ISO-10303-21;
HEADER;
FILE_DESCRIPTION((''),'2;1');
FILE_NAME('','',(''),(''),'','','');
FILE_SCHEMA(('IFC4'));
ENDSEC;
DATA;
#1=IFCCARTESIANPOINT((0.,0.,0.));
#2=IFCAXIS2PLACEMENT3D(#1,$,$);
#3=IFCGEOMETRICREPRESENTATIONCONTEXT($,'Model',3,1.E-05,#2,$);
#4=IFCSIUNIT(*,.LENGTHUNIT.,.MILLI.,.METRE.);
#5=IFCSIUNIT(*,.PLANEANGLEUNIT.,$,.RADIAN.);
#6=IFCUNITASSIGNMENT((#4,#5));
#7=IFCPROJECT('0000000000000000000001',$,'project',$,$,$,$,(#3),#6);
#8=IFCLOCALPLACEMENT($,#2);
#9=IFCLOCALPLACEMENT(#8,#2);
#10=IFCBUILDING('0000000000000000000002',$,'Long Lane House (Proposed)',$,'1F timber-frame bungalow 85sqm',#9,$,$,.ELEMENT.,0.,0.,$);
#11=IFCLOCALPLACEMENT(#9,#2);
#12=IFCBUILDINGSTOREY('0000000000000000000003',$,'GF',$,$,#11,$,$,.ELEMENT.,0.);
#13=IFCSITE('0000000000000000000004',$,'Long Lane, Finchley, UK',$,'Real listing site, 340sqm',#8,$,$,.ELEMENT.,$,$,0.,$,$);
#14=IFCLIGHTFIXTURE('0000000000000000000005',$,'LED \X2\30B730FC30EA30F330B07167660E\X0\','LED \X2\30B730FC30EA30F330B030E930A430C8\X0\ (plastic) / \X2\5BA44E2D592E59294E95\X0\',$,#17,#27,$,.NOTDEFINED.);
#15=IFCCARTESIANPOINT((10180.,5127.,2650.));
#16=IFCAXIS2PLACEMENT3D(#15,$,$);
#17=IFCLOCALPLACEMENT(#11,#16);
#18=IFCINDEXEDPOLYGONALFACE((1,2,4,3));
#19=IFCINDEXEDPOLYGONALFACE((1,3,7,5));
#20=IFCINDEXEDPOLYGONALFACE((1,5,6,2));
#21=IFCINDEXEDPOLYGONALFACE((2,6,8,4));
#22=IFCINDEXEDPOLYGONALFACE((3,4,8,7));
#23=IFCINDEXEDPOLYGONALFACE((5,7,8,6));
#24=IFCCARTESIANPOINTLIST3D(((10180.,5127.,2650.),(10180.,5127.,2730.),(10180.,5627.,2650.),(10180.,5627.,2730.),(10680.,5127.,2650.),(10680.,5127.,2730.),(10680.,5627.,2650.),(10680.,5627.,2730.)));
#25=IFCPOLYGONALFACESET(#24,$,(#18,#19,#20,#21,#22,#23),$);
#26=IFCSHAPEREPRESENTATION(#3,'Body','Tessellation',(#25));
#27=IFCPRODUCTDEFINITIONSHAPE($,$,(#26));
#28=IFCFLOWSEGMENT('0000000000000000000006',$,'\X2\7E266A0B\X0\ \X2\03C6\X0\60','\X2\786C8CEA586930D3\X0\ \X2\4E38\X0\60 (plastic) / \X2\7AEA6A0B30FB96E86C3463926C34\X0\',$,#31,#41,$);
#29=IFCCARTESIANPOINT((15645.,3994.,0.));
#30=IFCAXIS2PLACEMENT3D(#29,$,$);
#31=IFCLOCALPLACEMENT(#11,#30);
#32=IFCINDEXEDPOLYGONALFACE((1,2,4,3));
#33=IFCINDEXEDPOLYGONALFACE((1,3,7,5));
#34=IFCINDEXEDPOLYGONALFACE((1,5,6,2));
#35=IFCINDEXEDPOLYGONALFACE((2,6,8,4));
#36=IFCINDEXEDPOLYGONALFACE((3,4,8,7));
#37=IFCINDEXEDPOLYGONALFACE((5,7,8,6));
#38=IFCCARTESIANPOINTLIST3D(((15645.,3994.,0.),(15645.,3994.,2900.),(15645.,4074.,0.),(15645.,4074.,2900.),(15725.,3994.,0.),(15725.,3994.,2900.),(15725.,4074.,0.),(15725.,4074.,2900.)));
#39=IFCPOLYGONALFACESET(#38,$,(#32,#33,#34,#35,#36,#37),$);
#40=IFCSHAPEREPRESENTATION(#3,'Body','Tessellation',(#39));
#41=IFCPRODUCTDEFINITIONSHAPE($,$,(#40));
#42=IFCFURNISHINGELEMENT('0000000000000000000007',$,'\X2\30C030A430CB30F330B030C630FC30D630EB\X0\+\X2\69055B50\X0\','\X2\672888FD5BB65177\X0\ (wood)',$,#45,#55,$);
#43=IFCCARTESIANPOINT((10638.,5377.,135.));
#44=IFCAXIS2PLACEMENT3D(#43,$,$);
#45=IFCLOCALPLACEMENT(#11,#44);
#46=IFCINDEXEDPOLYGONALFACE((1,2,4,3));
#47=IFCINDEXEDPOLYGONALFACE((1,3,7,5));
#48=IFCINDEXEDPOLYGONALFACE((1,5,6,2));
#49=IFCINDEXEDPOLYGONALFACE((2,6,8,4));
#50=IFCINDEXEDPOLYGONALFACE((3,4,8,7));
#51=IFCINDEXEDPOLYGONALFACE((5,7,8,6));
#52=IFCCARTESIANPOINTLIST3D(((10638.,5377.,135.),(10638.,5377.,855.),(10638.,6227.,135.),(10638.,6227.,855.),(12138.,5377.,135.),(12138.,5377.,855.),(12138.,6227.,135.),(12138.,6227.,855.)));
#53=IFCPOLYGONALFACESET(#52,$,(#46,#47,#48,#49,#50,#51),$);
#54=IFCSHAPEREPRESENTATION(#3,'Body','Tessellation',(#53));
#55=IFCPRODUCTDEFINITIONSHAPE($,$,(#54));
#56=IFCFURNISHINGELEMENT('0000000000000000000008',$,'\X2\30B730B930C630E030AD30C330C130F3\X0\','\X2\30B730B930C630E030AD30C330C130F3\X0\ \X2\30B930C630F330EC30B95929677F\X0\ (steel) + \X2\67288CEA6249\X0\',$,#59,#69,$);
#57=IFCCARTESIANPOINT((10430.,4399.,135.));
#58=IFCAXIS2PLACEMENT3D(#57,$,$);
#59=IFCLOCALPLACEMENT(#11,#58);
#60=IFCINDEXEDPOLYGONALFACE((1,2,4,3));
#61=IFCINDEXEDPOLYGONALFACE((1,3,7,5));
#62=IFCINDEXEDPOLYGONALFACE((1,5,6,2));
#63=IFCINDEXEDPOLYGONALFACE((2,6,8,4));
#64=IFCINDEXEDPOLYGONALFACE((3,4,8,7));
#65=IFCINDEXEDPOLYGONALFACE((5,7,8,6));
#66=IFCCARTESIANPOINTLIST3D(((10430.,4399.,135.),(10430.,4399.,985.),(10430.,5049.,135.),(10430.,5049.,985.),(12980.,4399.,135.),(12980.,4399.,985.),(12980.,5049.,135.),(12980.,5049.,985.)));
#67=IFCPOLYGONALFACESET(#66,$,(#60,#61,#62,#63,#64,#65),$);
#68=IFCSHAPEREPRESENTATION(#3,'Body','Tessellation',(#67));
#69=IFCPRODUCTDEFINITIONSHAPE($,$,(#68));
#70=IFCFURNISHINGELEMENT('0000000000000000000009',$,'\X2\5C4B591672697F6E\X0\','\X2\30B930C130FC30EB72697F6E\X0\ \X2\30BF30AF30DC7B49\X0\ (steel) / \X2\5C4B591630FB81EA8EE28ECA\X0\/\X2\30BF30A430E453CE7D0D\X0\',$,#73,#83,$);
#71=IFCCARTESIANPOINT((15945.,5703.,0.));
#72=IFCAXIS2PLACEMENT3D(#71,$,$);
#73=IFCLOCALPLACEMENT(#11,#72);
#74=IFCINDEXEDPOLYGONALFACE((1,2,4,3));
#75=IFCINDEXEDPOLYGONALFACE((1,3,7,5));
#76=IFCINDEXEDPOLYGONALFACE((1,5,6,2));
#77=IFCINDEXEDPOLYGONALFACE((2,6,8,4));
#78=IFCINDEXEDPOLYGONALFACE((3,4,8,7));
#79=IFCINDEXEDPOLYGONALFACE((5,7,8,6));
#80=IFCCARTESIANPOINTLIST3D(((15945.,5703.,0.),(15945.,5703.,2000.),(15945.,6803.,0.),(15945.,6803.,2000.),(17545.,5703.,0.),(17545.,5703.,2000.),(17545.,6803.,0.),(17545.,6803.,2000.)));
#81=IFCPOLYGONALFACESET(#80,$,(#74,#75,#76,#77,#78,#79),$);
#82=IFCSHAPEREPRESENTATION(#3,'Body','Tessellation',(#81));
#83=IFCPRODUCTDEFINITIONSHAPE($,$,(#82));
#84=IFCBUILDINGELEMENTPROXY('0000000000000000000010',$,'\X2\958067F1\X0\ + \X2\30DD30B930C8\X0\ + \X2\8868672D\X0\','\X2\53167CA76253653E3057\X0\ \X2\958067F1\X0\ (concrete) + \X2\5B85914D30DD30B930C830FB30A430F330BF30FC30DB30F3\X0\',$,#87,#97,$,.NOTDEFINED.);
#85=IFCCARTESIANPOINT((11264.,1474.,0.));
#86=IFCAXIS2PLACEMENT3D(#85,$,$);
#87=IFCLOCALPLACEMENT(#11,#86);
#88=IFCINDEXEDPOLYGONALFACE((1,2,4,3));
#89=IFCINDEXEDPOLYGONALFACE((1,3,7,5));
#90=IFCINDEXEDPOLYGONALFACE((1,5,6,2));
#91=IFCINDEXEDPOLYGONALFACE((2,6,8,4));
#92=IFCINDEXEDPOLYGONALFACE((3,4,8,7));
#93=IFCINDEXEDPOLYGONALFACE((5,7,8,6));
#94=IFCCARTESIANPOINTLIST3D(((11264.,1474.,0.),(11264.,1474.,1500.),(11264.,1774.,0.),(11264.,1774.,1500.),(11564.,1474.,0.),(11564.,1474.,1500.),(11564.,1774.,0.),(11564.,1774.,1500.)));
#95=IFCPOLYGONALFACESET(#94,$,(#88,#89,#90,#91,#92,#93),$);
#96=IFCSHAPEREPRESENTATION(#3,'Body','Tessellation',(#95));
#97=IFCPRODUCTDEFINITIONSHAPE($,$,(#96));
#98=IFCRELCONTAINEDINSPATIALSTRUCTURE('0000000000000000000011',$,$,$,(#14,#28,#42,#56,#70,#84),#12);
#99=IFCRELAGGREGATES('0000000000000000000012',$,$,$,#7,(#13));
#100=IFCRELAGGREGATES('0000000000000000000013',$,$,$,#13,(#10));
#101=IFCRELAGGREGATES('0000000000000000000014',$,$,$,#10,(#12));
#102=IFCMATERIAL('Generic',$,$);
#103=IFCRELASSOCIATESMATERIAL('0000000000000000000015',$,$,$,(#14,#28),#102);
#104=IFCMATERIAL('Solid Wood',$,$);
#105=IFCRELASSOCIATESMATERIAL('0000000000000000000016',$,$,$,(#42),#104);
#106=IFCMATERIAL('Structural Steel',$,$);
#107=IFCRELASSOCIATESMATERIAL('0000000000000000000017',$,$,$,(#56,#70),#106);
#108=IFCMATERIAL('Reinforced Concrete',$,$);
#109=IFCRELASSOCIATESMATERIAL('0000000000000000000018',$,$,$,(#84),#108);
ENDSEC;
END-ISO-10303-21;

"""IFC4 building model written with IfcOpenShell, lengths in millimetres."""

from ifc_helpers import new_model, si_unit, frame, frame_2d, origin, place, context, project, spatial, rectangle, extrude, material, element, save


model = new_model("IFC4")

# Units and contexts
model_context = context("Model", 3, precision=1e-05, world=origin())
ifc_project = project(units=[si_unit("LENGTHUNIT", "METRE", prefix="MILLI"), si_unit("PLANEANGLEUNIT", "RADIAN")], contexts=[model_context])

# Site, building, storey
site_placement = place(None, origin())
site = spatial("IfcSite", under=ifc_project, at=site_placement, Name="Long Lane, Finchley, UK", ObjectType="Real listing site, 340sqm", CompositionType="ELEMENT", RefElevation=0.0)
building_placement = place(site_placement, origin())
building = spatial("IfcBuilding", under=site, at=building_placement, Name="Long Lane House (Proposed)", ObjectType="1F timber-frame bungalow 85sqm", CompositionType="ELEMENT", ElevationOfRefHeight=0.0, ElevationOfTerrain=0.0)
storey_placement = place(building_placement, origin())
storey = spatial("IfcBuildingStorey", under=building, at=storey_placement, Name="GF", CompositionType="ELEMENT", Elevation=0.0)

# Shared definitions
ifc_material_1 = material(Name="Solid Wood")

# Shared definitions
ifc_material_2 = material(Name="Structural Steel")

# Shared definitions
ifc_material_3 = material(Name="Reinforced Concrete")

# Shared definitions
ifc_material_4 = material(Name="Generic")

# Light fixture
light_fixture_placement = place(storey_placement, frame((10180.0, 5127.0, 2650.0)))
element("IfcLightFixture", 1, at=light_fixture_placement, inside=storey, material=ifc_material_4, Name="LED シーリング照明", Description="LED シーリングライト (plastic) / 室中央天井", PredefinedType="NOTDEFINED", context=model_context, shape_type="SweptSolid", body=[
    extrude(rectangle(XDim=500.0, YDim=500.0, at=frame_2d((250.0, 250.0))), frame((10180.0, 5127.0, 2650.0)), (0.0, 0.0, 1.0), 80.0),
])

# Flow segment
flow_segment_placement = place(storey_placement, frame((15645.0, 3994.0, 0.0)))
element("IfcFlowSegment", 2, at=flow_segment_placement, inside=storey, material=ifc_material_4, Name="縦樋 φ60", Description="硬質塩ビ 丸60 (plastic) / 竪樋・雨水排水", context=model_context, shape_type="SweptSolid", body=[
    extrude(rectangle(XDim=80.0, YDim=80.0, at=frame_2d((40.0, 40.0))), frame((15645.0, 3994.0, 0.0)), (0.0, 0.0, 1.0), 2900.0),
])

# Furnishing elements
furnishing_1_placement = place(storey_placement, frame((10638.0, 5377.0, 135.0)))
element("IfcFurnishingElement", 3, at=furnishing_1_placement, inside=storey, material=ifc_material_1, Name="ダイニングテーブル+椅子", Description="木製家具 (wood)", context=model_context, shape_type="SweptSolid", body=[
    extrude(rectangle(XDim=1500.0, YDim=850.0, at=frame_2d((750.0, 425.0))), frame((10638.0, 5377.0, 135.0)), (0.0, 0.0, 1.0), 720.0),
])
furnishing_2_placement = place(storey_placement, frame((10430.0, 4399.0, 135.0)))
element("IfcFurnishingElement", 4, at=furnishing_2_placement, inside=storey, material=ifc_material_2, Name="システムキッチン", Description="システムキッチン ステンレス天板 (steel) + 木質扉", context=model_context, shape_type="SweptSolid", body=[
    extrude(rectangle(XDim=2550.0, YDim=650.0, at=frame_2d((1275.0, 325.0))), frame((10430.0, 4399.0, 135.0)), (0.0, 0.0, 1.0), 850.0),
])
furnishing_3_placement = place(storey_placement, frame((15945.0, 5703.0, 0.0)))
element("IfcFurnishingElement", 5, at=furnishing_3_placement, inside=storey, material=ifc_material_2, Name="屋外物置", Description="スチール物置 タクボ等 (steel) / 屋外・自転車/タイヤ収納", context=model_context, shape_type="SweptSolid", body=[
    extrude(rectangle(XDim=1600.0, YDim=1100.0, at=frame_2d((800.0, 550.0))), frame((15945.0, 5703.0, 0.0)), (0.0, 0.0, 1.0), 2000.0),
])

# Building element proxy
proxy_placement = place(storey_placement, frame((11264.0, 1474.0, 0.0)))
element("IfcBuildingElementProxy", 6, at=proxy_placement, inside=storey, material=ifc_material_3, Name="門柱 + ポスト + 表札", Description="化粧打放し 門柱 (concrete) + 宅配ポスト・インターホン", PredefinedType="NOTDEFINED", context=model_context, shape_type="SweptSolid", body=[
    extrude(rectangle(XDim=300.0, YDim=300.0, at=frame_2d((150.0, 150.0))), frame((11264.0, 1474.0, 0.0)), (0.0, 0.0, 1.0), 1500.0),
])

save(model, "model.ifc")
